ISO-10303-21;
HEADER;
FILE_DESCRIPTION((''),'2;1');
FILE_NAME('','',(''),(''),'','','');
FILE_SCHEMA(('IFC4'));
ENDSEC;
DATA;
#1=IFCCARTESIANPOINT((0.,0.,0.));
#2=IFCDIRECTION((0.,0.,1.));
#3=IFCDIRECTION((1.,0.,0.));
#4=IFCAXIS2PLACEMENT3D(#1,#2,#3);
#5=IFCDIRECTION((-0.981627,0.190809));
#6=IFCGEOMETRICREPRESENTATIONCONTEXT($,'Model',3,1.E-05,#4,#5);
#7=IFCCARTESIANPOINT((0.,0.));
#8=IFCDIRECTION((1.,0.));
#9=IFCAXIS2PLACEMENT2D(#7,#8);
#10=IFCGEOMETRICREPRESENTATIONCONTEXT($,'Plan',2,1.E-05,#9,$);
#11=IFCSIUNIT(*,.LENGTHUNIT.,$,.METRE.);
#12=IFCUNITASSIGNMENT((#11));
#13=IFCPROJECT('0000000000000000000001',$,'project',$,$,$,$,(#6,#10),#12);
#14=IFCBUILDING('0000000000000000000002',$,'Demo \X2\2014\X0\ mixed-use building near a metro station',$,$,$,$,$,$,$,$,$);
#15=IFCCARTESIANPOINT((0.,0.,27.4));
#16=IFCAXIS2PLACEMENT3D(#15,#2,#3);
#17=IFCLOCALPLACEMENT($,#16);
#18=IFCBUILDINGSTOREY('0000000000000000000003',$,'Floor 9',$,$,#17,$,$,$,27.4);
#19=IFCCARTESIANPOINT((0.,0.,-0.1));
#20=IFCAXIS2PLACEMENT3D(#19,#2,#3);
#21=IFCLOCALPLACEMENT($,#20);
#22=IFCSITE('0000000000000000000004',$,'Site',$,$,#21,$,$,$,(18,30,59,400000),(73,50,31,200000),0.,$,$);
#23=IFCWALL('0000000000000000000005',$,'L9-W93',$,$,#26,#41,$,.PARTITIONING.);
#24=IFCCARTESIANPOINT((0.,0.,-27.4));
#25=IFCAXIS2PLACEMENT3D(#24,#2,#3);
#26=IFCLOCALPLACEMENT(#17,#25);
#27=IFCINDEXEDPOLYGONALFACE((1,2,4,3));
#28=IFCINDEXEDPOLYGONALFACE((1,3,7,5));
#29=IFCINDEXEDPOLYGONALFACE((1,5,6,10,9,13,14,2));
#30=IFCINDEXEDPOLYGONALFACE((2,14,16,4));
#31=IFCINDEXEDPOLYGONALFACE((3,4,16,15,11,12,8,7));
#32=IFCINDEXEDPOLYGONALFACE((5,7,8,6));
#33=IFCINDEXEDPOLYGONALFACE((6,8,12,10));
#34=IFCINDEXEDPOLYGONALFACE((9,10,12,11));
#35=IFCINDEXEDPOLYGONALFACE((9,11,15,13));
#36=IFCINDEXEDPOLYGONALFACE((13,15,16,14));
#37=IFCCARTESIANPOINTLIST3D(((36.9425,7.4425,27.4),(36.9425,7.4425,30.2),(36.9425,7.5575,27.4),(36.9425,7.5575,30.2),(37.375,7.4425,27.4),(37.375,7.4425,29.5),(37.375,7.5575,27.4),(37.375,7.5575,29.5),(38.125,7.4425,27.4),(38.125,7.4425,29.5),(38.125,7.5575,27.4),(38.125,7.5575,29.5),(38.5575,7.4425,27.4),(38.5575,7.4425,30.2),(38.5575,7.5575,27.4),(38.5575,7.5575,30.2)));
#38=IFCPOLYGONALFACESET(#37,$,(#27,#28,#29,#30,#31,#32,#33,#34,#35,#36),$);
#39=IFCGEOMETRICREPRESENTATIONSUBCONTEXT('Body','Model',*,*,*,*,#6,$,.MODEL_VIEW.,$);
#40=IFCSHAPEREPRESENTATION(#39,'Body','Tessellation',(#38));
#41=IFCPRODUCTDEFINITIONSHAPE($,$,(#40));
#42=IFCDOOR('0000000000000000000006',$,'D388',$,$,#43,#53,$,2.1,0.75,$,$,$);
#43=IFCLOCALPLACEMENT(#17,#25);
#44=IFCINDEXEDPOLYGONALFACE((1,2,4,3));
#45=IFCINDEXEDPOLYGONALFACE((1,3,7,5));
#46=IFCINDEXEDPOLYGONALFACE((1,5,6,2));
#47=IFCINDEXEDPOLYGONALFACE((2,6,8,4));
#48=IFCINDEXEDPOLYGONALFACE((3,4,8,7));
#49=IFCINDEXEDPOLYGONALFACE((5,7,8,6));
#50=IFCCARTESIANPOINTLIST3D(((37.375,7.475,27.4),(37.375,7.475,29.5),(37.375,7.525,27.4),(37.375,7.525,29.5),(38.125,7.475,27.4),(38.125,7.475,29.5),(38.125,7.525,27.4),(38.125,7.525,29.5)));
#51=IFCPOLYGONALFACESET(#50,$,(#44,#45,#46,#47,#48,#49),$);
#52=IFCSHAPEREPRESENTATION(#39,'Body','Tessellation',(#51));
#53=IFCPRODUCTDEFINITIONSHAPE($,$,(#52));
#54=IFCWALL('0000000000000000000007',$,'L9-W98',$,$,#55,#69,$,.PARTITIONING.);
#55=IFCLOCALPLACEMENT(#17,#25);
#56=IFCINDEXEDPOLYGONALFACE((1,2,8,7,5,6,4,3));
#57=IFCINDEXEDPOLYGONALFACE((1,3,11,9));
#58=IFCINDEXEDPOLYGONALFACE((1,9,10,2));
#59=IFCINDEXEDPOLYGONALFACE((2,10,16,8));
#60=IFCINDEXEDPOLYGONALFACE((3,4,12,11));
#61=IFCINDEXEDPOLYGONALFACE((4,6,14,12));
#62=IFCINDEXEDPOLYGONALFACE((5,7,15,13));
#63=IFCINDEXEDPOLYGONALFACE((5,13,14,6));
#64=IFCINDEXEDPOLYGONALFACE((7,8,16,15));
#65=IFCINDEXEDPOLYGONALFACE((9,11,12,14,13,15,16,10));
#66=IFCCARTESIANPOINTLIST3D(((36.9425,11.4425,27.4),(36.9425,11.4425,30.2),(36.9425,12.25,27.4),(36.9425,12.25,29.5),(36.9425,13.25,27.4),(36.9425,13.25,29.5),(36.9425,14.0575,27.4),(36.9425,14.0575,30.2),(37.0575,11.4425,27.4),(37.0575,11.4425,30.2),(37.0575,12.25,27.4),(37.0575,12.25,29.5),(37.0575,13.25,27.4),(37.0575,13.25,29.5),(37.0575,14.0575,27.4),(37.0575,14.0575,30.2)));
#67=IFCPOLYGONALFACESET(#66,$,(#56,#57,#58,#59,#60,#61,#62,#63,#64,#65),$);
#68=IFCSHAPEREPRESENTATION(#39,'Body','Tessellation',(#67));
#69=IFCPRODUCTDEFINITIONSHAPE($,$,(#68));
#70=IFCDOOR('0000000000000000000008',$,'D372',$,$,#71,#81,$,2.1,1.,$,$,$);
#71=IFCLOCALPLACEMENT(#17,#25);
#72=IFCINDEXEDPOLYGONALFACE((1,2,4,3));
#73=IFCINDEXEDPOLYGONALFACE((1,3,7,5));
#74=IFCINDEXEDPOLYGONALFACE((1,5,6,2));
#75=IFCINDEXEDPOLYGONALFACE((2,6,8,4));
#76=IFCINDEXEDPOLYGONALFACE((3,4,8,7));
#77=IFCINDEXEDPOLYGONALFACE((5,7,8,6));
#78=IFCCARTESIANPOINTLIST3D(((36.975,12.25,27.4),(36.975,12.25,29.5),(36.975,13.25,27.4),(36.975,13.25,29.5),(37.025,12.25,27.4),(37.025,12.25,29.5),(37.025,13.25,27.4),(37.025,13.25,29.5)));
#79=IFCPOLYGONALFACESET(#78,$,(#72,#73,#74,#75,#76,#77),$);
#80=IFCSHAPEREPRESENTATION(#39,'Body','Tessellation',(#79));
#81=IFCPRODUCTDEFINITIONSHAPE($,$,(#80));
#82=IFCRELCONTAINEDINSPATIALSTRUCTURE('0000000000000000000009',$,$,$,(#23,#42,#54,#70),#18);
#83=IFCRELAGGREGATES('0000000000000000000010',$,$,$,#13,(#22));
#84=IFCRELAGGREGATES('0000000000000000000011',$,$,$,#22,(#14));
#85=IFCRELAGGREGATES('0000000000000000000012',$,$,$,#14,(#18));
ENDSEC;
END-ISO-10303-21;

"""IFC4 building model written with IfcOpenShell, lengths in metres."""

from ifc_helpers import new_model, si_unit, direction, frame, origin_with_axes, origin_2d_with_axis, place, context, subcontext, project, spatial, line, indexed_curve, outline, extrude, element, fill, save


model = new_model("IFC4")

# Units and contexts
model_context = context("Model", 3, precision=1e-05, world=origin_with_axes(), true_north=direction((-0.981627, 0.190809)))
plan_context = context("Plan", 2, precision=1e-05, world=origin_2d_with_axis())
body_context = subcontext(model_context, "Body", "Model", "MODEL_VIEW")
ifc_project = project(units=[si_unit("LENGTHUNIT", "METRE")], contexts=[model_context, plan_context])

# Site, building, storey
site_placement = place(None, frame((0.0, 0.0, -0.1), z_axis=(0.0, 0.0, 1.0), x_axis=(1.0, 0.0, 0.0)))
site = spatial("IfcSite", under=ifc_project, at=site_placement, Name="Site", RefLatitude=(18, 30, 59, 400000), RefLongitude=(73, 50, 31, 200000), RefElevation=0.0)
building = spatial("IfcBuilding", under=site, Name="Demo — mixed-use building near a metro station")
storey_placement = place(None, frame((0.0, 0.0, 27.4), z_axis=(0.0, 0.0, 1.0), x_axis=(1.0, 0.0, 0.0)))
storey = spatial("IfcBuildingStorey", under=building, at=storey_placement, Name="Floor 9", Elevation=27.4)

# Wall, opening, door
wall_1_placement = place(storey_placement, frame((0.0, 0.0, -27.4), z_axis=(0.0, 0.0, 1.0), x_axis=(1.0, 0.0, 0.0)))
wall_1 = element("IfcWall", 1, at=wall_1_placement, inside=storey, Name="L9-W93", PredefinedType="PARTITIONING", context=body_context, shape_type="SweptSolid", body=[
    extrude(outline(indexed_curve([(38.5575, 7.4425), (36.9425, 7.4425), (36.9425, 7.5575), (38.5575, 7.5575)], segments=[line(1, 2, 3, 4, 1)])), frame((0.0, 0.0, 27.4), z_axis=(0.0, 0.0, 1.0), x_axis=(1.0, 0.0, 0.0)), (0.0, 0.0, 1.0), 2.8),
])
opening_1_placement = place(wall_1_placement, origin_with_axes())
opening_1 = element("IfcOpeningElement", 2, at=opening_1_placement, cuts=wall_1, context=body_context, shape_type="SweptSolid", body=[
    extrude(outline(indexed_curve([(38.125, 7.3925), (37.375, 7.3925), (37.375, 7.6075), (38.125, 7.6075)], segments=[line(1, 2, 3, 4, 1)])), frame((0.0, 0.0, 27.4), z_axis=(0.0, 0.0, 1.0), x_axis=(1.0, 0.0, 0.0)), (0.0, 0.0, 1.0), 2.1),
])
door_1_placement = place(storey_placement, frame((0.0, 0.0, -27.4), z_axis=(0.0, 0.0, 1.0), x_axis=(1.0, 0.0, 0.0)))
door_1 = element("IfcDoor", 3, at=door_1_placement, inside=storey, Name="D388", OverallHeight=2.1, OverallWidth=0.75, context=body_context, shape_type="SweptSolid", body=[
    extrude(outline(indexed_curve([(38.125, 7.475), (37.375, 7.475), (37.375, 7.525), (38.125, 7.525)], segments=[line(1, 2, 3, 4, 1)])), frame((0.0, 0.0, 27.4), z_axis=(0.0, 0.0, 1.0), x_axis=(1.0, 0.0, 0.0)), (0.0, 0.0, 1.0), 2.1),
])
fill(opening_1, door_1)

# Wall, opening, door
wall_2_placement = place(storey_placement, frame((0.0, 0.0, -27.4), z_axis=(0.0, 0.0, 1.0), x_axis=(1.0, 0.0, 0.0)))
wall_2 = element("IfcWall", 4, at=wall_2_placement, inside=storey, Name="L9-W98", PredefinedType="PARTITIONING", context=body_context, shape_type="SweptSolid", body=[
    extrude(outline(indexed_curve([(36.9425, 11.4425), (36.9425, 14.0575), (37.0575, 14.0575), (37.0575, 11.4425)], segments=[line(1, 2, 3, 4, 1)])), frame((0.0, 0.0, 27.4), z_axis=(0.0, 0.0, 1.0), x_axis=(1.0, 0.0, 0.0)), (0.0, 0.0, 1.0), 2.8),
])
opening_2_placement = place(wall_2_placement, origin_with_axes())
opening_2 = element("IfcOpeningElement", 5, at=opening_2_placement, cuts=wall_2, context=body_context, shape_type="SweptSolid", body=[
    extrude(outline(indexed_curve([(36.8925, 12.25), (36.8925, 13.25), (37.1075, 13.25), (37.1075, 12.25)], segments=[line(1, 2, 3, 4, 1)])), frame((0.0, 0.0, 27.4), z_axis=(0.0, 0.0, 1.0), x_axis=(1.0, 0.0, 0.0)), (0.0, 0.0, 1.0), 2.1),
])
door_2_placement = place(storey_placement, frame((0.0, 0.0, -27.4), z_axis=(0.0, 0.0, 1.0), x_axis=(1.0, 0.0, 0.0)))
door_2 = element("IfcDoor", 6, at=door_2_placement, inside=storey, Name="D372", OverallHeight=2.1, OverallWidth=1.0, context=body_context, shape_type="SweptSolid", body=[
    extrude(outline(indexed_curve([(36.975, 12.25), (36.975, 13.25), (37.025, 13.25), (37.025, 12.25)], segments=[line(1, 2, 3, 4, 1)])), frame((0.0, 0.0, 27.4), z_axis=(0.0, 0.0, 1.0), x_axis=(1.0, 0.0, 0.0)), (0.0, 0.0, 1.0), 2.1),
])
fill(opening_2, door_2)

save(model, "model.ifc")
